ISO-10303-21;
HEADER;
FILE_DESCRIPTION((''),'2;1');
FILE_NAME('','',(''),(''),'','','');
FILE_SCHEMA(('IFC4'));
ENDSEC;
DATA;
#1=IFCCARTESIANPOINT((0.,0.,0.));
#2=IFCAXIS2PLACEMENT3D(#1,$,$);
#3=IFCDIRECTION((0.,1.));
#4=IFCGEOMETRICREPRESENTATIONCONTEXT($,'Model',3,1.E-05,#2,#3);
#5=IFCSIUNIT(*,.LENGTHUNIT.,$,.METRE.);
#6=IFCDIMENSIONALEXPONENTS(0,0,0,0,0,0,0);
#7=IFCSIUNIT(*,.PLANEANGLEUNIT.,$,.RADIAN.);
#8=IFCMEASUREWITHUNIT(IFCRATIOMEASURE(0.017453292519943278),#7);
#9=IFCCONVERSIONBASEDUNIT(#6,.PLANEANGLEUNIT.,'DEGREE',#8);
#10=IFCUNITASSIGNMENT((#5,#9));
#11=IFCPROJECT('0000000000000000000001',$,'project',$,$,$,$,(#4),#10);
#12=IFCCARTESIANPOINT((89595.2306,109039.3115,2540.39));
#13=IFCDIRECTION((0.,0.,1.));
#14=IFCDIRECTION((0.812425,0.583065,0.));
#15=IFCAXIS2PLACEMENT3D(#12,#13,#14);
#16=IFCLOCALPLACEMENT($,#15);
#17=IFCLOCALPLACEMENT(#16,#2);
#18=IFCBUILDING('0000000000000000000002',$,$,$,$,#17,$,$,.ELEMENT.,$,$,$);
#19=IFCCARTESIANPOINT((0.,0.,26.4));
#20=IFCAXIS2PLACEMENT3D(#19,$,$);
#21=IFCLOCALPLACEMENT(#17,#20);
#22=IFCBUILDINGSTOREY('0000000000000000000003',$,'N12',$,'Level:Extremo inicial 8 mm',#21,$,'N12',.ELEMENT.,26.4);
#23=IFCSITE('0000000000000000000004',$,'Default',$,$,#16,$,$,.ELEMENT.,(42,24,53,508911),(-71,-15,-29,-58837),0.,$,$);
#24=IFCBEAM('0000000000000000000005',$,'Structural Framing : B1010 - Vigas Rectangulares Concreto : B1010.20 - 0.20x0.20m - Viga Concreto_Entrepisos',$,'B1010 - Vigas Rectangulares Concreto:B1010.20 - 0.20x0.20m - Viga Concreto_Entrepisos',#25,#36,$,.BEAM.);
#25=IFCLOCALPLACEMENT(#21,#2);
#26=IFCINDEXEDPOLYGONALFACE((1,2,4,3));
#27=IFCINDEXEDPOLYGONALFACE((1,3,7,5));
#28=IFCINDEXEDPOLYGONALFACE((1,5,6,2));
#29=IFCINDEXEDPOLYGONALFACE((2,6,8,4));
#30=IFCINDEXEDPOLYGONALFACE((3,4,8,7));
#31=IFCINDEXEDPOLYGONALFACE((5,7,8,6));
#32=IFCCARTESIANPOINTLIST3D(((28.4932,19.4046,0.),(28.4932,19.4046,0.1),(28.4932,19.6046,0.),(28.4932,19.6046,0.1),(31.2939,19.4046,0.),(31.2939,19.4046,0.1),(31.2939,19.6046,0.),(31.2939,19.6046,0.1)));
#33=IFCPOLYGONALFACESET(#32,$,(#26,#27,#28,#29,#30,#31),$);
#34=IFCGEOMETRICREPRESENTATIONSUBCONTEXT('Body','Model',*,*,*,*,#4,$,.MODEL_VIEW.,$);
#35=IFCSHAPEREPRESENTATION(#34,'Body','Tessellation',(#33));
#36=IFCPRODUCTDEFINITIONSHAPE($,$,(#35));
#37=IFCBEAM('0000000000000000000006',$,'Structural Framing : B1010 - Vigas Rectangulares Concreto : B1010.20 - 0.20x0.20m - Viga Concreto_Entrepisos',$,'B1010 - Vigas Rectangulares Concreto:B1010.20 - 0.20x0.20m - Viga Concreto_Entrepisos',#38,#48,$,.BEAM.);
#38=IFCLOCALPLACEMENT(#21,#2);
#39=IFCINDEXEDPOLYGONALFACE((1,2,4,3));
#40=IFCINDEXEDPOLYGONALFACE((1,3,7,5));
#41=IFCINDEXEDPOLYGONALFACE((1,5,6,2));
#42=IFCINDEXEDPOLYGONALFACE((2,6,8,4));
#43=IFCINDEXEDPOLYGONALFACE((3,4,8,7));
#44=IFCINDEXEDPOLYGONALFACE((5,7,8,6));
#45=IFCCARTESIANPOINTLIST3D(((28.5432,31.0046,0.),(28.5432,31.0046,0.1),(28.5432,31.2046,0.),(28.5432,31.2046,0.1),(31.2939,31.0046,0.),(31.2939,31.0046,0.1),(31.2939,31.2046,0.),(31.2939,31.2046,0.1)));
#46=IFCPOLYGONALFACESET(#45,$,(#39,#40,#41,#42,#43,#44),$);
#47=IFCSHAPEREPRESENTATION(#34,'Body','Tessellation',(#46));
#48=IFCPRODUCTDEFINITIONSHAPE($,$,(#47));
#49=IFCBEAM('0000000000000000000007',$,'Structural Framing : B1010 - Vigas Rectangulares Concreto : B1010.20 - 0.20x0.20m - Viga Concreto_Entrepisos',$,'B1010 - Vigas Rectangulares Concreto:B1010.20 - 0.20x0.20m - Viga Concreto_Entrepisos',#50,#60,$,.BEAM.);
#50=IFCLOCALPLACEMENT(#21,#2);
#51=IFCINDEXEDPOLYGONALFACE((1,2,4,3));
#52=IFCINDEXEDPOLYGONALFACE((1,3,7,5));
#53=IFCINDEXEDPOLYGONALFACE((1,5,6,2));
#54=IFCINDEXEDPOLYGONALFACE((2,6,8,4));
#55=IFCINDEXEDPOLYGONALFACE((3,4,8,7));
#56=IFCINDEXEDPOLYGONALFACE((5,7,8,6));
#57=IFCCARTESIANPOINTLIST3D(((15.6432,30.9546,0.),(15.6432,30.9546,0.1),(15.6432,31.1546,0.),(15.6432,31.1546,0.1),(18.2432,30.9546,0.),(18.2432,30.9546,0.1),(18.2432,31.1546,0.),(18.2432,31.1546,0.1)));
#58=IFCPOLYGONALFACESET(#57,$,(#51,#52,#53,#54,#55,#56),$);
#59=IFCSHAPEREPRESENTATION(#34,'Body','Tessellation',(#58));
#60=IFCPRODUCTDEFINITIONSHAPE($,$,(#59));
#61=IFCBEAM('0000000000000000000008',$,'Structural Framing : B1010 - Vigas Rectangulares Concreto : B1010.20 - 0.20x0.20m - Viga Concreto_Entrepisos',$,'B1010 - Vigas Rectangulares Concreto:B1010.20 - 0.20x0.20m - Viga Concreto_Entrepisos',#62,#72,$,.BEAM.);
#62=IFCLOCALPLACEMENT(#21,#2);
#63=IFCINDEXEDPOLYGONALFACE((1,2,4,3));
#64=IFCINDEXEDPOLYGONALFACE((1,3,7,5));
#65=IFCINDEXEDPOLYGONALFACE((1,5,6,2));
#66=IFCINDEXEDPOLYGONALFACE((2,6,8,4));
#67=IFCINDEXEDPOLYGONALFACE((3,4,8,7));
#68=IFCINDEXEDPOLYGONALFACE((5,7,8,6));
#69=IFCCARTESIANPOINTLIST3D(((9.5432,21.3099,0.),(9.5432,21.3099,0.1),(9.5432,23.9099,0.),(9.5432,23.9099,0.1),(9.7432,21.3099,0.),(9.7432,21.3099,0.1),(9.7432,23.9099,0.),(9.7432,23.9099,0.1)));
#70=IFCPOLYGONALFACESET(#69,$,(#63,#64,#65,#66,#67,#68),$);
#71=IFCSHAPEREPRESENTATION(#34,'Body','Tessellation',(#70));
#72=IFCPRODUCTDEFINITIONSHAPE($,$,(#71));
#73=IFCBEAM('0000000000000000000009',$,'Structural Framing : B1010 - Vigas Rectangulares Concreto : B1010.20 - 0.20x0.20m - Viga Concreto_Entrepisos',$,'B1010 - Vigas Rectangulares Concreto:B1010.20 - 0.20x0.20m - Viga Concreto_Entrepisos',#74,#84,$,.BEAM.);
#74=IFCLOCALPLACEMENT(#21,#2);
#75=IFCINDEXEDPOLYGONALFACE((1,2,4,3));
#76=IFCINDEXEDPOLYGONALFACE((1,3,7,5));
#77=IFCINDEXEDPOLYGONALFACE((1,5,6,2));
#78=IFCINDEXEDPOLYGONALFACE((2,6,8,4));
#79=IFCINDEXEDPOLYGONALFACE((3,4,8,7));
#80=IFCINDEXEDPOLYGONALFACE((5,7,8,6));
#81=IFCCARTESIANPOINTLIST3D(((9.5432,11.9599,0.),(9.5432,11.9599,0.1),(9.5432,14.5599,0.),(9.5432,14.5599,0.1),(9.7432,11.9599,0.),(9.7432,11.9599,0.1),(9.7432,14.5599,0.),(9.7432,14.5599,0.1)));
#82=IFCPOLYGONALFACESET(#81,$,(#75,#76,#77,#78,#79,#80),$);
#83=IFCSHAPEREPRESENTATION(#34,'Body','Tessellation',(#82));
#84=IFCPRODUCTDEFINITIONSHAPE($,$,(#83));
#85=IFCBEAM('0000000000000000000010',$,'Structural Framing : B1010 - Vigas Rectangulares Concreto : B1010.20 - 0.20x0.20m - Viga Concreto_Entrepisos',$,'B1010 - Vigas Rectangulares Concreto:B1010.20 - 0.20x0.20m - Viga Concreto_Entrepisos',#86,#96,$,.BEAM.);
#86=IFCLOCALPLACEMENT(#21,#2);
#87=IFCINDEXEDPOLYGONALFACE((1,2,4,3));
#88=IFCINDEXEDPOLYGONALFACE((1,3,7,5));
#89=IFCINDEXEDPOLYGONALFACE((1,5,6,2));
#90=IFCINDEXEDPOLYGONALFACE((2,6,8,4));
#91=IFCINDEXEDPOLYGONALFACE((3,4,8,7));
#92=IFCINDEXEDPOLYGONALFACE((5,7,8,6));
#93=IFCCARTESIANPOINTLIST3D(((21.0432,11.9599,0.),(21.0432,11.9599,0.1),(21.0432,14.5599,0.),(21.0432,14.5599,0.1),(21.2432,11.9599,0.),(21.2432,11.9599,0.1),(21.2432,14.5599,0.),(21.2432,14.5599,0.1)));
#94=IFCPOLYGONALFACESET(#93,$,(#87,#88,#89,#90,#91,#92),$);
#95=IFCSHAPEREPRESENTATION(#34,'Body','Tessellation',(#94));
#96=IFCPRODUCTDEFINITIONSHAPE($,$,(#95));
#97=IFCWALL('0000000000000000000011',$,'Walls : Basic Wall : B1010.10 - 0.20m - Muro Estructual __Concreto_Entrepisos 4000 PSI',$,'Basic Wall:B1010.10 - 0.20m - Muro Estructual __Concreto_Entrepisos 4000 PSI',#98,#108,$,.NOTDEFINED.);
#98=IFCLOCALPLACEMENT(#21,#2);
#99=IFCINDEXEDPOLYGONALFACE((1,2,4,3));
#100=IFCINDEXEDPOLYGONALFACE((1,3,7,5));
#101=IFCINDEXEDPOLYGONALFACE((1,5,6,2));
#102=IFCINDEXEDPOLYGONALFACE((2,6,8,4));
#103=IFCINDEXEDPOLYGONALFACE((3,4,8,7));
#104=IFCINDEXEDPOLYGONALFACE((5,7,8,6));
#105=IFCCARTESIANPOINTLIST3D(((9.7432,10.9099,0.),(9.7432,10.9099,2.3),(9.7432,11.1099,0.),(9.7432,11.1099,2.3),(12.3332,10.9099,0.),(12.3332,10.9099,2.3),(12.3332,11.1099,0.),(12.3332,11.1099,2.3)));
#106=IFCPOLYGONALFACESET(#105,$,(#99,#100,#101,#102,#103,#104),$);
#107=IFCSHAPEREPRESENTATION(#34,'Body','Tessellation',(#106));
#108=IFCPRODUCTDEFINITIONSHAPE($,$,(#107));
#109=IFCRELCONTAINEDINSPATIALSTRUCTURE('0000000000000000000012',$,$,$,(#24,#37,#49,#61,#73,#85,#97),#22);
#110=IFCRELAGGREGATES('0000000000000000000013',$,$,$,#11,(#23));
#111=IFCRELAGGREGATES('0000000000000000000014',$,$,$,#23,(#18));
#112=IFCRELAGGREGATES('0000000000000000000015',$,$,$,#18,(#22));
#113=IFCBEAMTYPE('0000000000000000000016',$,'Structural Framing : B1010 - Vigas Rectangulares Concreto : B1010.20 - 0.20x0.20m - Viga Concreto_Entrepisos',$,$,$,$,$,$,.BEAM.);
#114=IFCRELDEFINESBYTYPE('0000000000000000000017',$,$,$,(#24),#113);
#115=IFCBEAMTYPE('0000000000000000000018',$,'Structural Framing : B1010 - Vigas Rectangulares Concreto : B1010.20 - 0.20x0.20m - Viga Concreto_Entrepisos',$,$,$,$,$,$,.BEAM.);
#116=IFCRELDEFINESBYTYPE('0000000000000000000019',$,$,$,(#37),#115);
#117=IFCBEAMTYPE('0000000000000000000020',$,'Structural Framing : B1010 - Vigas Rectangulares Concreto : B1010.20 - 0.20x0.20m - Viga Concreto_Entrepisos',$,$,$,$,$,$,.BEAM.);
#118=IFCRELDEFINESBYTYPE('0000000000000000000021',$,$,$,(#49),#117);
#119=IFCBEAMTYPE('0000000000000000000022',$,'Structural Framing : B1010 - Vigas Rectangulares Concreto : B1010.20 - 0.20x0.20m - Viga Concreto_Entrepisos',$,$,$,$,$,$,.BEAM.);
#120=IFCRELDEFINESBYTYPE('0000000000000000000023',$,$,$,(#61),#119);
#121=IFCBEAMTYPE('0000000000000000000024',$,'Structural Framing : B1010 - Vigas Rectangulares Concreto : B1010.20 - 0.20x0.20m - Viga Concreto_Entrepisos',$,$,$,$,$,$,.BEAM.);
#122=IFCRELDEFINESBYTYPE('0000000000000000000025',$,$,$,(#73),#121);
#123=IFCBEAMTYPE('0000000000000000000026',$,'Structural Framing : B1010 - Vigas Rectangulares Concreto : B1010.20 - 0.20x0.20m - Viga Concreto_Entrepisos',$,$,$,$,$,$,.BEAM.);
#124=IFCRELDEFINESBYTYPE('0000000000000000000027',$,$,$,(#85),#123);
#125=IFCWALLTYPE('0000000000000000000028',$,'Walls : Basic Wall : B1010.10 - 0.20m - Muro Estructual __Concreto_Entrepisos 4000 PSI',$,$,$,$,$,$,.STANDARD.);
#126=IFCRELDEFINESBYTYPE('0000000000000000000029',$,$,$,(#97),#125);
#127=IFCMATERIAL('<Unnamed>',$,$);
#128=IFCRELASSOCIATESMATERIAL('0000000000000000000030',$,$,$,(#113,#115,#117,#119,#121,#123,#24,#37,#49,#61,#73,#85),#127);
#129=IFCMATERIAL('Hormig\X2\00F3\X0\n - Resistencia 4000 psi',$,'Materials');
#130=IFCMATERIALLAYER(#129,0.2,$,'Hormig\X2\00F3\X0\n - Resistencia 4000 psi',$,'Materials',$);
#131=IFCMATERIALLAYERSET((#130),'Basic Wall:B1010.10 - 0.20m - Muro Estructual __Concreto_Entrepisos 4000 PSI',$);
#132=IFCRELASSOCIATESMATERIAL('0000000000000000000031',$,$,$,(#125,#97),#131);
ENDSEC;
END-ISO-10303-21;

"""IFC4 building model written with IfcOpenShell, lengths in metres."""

from ifc_helpers import new_model, entity, si_unit, converted_unit, direction, frame, frame_2d, origin, place, context, subcontext, project, spatial, polyline, segment, composite_curve, rectangle, outline, extrude, source, transform, mapped, material, layer, layer_set, layer_usage, material_profile, profile_set, profile_usage, type_object, type_shapes, element, save


model = new_model("IFC4")

# Units and contexts
model_context = context("Model", 3, precision=1e-05, world=origin(), true_north=direction((0.0, 1.0)))
body_context = subcontext(model_context, "Body", "Model", "MODEL_VIEW")
ifc_project = project(units=[si_unit("LENGTHUNIT", "METRE"), converted_unit("PLANEANGLEUNIT", "DEGREE", entity("IfcRatioMeasure", 0.017453292519943278), si_unit("PLANEANGLEUNIT", "RADIAN"), dimensions=[0, 0, 0, 0, 0, 0, 0])], contexts=[model_context])

# Site, building, storey
site_placement = place(None, frame((89595.2306, 109039.3115, 2540.39), z_axis=(0.0, 0.0, 1.0), x_axis=(0.812425, 0.583065, 0.0)))
site = spatial("IfcSite", under=ifc_project, at=site_placement, Name="Default", CompositionType="ELEMENT", RefLatitude=(42, 24, 53, 508911), RefLongitude=(-71, -15, -29, -58837), RefElevation=0.0)
building_placement = place(site_placement, origin())
building = spatial("IfcBuilding", under=site, at=building_placement, CompositionType="ELEMENT")
storey_placement = place(building_placement, frame((0.0, 0.0, 26.4)))
storey = spatial("IfcBuildingStorey", under=building, at=storey_placement, Name="N12", ObjectType="Level:Extremo inicial 8 mm", LongName="N12", CompositionType="ELEMENT", Elevation=26.4)

# Beams
ifc_material_1 = material(Name="<Unnamed>")
ifc_material_profile_1 = material_profile(ifc_material_1, outline(composite_curve([segment(polyline([(-0.1, 0.0, 0.0), (-0.1, 0.1, 0.0)]), True, "CONTINUOUS"), segment(polyline([(-0.1, 0.1, 0.0), (0.1, 0.1, 0.0)]), True, "CONTINUOUS"), segment(polyline([(0.1, 0.1, 0.0), (0.1, 0.0, 0.0)]), True, "CONTINUOUS"), segment(polyline([(0.1, 0.0, 0.0), (-0.1, 0.0, 0.0)]), True, "CONTINUOUS")], self_intersect=False), kind="CURVE"), Name="B1010.20 - 0.20x0.20m - Viga Concreto_Entrepisos")
ifc_material_profile_2 = material_profile(ifc_material_1, outline(composite_curve([segment(polyline([(-1.4004, -0.1, 0.1), (-1.4004, 0.1, 0.1)]), True, "CONTINUOUS"), segment(polyline([(-1.4004, 0.1, 0.1), (-1.4004, 0.1, -0.1)]), True, "CONTINUOUS"), segment(polyline([(-1.4004, 0.1, -0.1), (-1.4004, -0.1, -0.1)]), True, "CONTINUOUS"), segment(polyline([(-1.4004, -0.1, -0.1), (-1.4004, -0.1, 0.1)]), True, "CONTINUOUS")], self_intersect=False), kind="CURVE"), Name="B1010.20 - 0.20x0.20m - Viga Concreto_Entrepisos")
ifc_profile_set_1 = profile_set([ifc_material_profile_1, ifc_material_profile_2], Name="B1010.20 - 0.20x0.20m - Viga Concreto_Entrepisos")
ifc_profile_usage_1 = profile_usage(ifc_profile_set_1, cardinal=8)
beam_type_1 = type_object("IfcBeamType", Name="Structural Framing : B1010 - Vigas Rectangulares Concreto : B1010.20 - 0.20x0.20m - Viga Concreto_Entrepisos", PredefinedType="BEAM", material=ifc_profile_set_1)
shared_shape_1 = source(origin(), body_context, "Body", "SweptSolid", [
    extrude(rectangle(XDim=0.1, YDim=0.2, at=frame_2d((0.0, 0.0), x_axis=(1.0, 0.0))), frame((31.2939, 19.5046, 26.45), z_axis=(-1.0, 0.0, 0.0), x_axis=(0.0, 0.0, -1.0)), (0.0, 0.0, 1.0), 2.8007),
])
type_shapes(beam_type_1, [shared_shape_1])
beam_1_placement = place(storey_placement, frame((0.0, 0.0, -26.4)))
element("IfcBeam", 1, at=beam_1_placement, inside=storey, type_object=beam_type_1, material=ifc_profile_usage_1, Name="Structural Framing : B1010 - Vigas Rectangulares Concreto : B1010.20 - 0.20x0.20m - Viga Concreto_Entrepisos", ObjectType="B1010 - Vigas Rectangulares Concreto:B1010.20 - 0.20x0.20m - Viga Concreto_Entrepisos", PredefinedType="BEAM", context=body_context, shape_type="MappedRepresentation", body=[
    mapped(shared_shape_1, transform((0.0, 0.0, 0.0), scale=1.0)),
])
ifc_profile_usage_2 = profile_usage(ifc_profile_set_1, cardinal=8)
beam_type_2 = type_object("IfcBeamType", Name="Structural Framing : B1010 - Vigas Rectangulares Concreto : B1010.20 - 0.20x0.20m - Viga Concreto_Entrepisos", PredefinedType="BEAM", material=ifc_profile_set_1)
shared_shape_2 = source(origin(), body_context, "Body", "SweptSolid", [
    extrude(rectangle(XDim=0.1, YDim=0.2, at=frame_2d((0.0, 0.0), x_axis=(1.0, 0.0))), frame((31.2939, 31.1046, 26.45), z_axis=(-1.0, 0.0, 0.0), x_axis=(0.0, 0.0, -1.0)), (0.0, 0.0, 1.0), 2.7507),
])
type_shapes(beam_type_2, [shared_shape_2])
beam_2_placement = place(storey_placement, frame((0.0, 0.0, -26.4)))
element("IfcBeam", 2, at=beam_2_placement, inside=storey, type_object=beam_type_2, material=ifc_profile_usage_2, Name="Structural Framing : B1010 - Vigas Rectangulares Concreto : B1010.20 - 0.20x0.20m - Viga Concreto_Entrepisos", ObjectType="B1010 - Vigas Rectangulares Concreto:B1010.20 - 0.20x0.20m - Viga Concreto_Entrepisos", PredefinedType="BEAM", context=body_context, shape_type="MappedRepresentation", body=[
    mapped(shared_shape_2, transform((0.0, 0.0, 0.0), scale=1.0)),
])
ifc_profile_usage_3 = profile_usage(ifc_profile_set_1, cardinal=8)
beam_type_3 = type_object("IfcBeamType", Name="Structural Framing : B1010 - Vigas Rectangulares Concreto : B1010.20 - 0.20x0.20m - Viga Concreto_Entrepisos", PredefinedType="BEAM", material=ifc_profile_set_1)
shared_shape_3 = source(origin(), body_context, "Body", "SweptSolid", [
    extrude(rectangle(XDim=0.1, YDim=0.2, at=frame_2d((0.0, 0.0), x_axis=(1.0, 0.0))), frame((18.2432, 31.0546, 26.45), z_axis=(-1.0, 0.0, 0.0), x_axis=(0.0, 0.0, -1.0)), (0.0, 0.0, 1.0), 2.6),
])
type_shapes(beam_type_3, [shared_shape_3])
beam_3_placement = place(storey_placement, frame((0.0, 0.0, -26.4)))
element("IfcBeam", 3, at=beam_3_placement, inside=storey, type_object=beam_type_3, material=ifc_profile_usage_3, Name="Structural Framing : B1010 - Vigas Rectangulares Concreto : B1010.20 - 0.20x0.20m - Viga Concreto_Entrepisos", ObjectType="B1010 - Vigas Rectangulares Concreto:B1010.20 - 0.20x0.20m - Viga Concreto_Entrepisos", PredefinedType="BEAM", context=body_context, shape_type="MappedRepresentation", body=[
    mapped(shared_shape_3, transform((0.0, 0.0, 0.0), scale=1.0)),
])
ifc_profile_usage_4 = profile_usage(ifc_profile_set_1, cardinal=8)
beam_type_4 = type_object("IfcBeamType", Name="Structural Framing : B1010 - Vigas Rectangulares Concreto : B1010.20 - 0.20x0.20m - Viga Concreto_Entrepisos", PredefinedType="BEAM", material=ifc_profile_set_1)
shared_shape_4 = source(origin(), body_context, "Body", "SweptSolid", [
    extrude(rectangle(XDim=0.1, YDim=0.2, at=frame_2d((0.0, 0.0), x_axis=(0.0, 1.0))), frame((9.6432, 21.3099, 26.45), z_axis=(0.0, 1.0, 0.0), x_axis=(-1.0, 0.0, 0.0)), (0.0, 0.0, 1.0), 2.6),
])
type_shapes(beam_type_4, [shared_shape_4])
beam_4_placement = place(storey_placement, frame((0.0, 0.0, -26.4)))
element("IfcBeam", 4, at=beam_4_placement, inside=storey, type_object=beam_type_4, material=ifc_profile_usage_4, Name="Structural Framing : B1010 - Vigas Rectangulares Concreto : B1010.20 - 0.20x0.20m - Viga Concreto_Entrepisos", ObjectType="B1010 - Vigas Rectangulares Concreto:B1010.20 - 0.20x0.20m - Viga Concreto_Entrepisos", PredefinedType="BEAM", context=body_context, shape_type="MappedRepresentation", body=[
    mapped(shared_shape_4, transform((0.0, 0.0, 0.0), scale=1.0)),
])
ifc_profile_usage_5 = profile_usage(ifc_profile_set_1, cardinal=8)
beam_type_5 = type_object("IfcBeamType", Name="Structural Framing : B1010 - Vigas Rectangulares Concreto : B1010.20 - 0.20x0.20m - Viga Concreto_Entrepisos", PredefinedType="BEAM", material=ifc_profile_set_1)
shared_shape_5 = source(origin(), body_context, "Body", "SweptSolid", [
    extrude(rectangle(XDim=0.1, YDim=0.2, at=frame_2d((0.0, 0.0), x_axis=(0.0, 1.0))), frame((9.6432, 11.9599, 26.45), z_axis=(0.0, 1.0, 0.0), x_axis=(-1.0, 0.0, 0.0)), (0.0, 0.0, 1.0), 2.6),
])
type_shapes(beam_type_5, [shared_shape_5])
beam_5_placement = place(storey_placement, frame((0.0, 0.0, -26.4)))
element("IfcBeam", 5, at=beam_5_placement, inside=storey, type_object=beam_type_5, material=ifc_profile_usage_5, Name="Structural Framing : B1010 - Vigas Rectangulares Concreto : B1010.20 - 0.20x0.20m - Viga Concreto_Entrepisos", ObjectType="B1010 - Vigas Rectangulares Concreto:B1010.20 - 0.20x0.20m - Viga Concreto_Entrepisos", PredefinedType="BEAM", context=body_context, shape_type="MappedRepresentation", body=[
    mapped(shared_shape_5, transform((0.0, 0.0, 0.0), scale=1.0)),
])
ifc_profile_usage_6 = profile_usage(ifc_profile_set_1, cardinal=8)
beam_type_6 = type_object("IfcBeamType", Name="Structural Framing : B1010 - Vigas Rectangulares Concreto : B1010.20 - 0.20x0.20m - Viga Concreto_Entrepisos", PredefinedType="BEAM", material=ifc_profile_set_1)
shared_shape_6 = source(origin(), body_context, "Body", "SweptSolid", [
    extrude(rectangle(XDim=0.1, YDim=0.2, at=frame_2d((0.0, 0.0), x_axis=(0.0, 1.0))), frame((21.1432, 11.9599, 26.45), z_axis=(0.0, 1.0, 0.0), x_axis=(-1.0, 0.0, 0.0)), (0.0, 0.0, 1.0), 2.6),
])
type_shapes(beam_type_6, [shared_shape_6])
beam_6_placement = place(storey_placement, frame((0.0, 0.0, -26.4)))
element("IfcBeam", 6, at=beam_6_placement, inside=storey, type_object=beam_type_6, material=ifc_profile_usage_6, Name="Structural Framing : B1010 - Vigas Rectangulares Concreto : B1010.20 - 0.20x0.20m - Viga Concreto_Entrepisos", ObjectType="B1010 - Vigas Rectangulares Concreto:B1010.20 - 0.20x0.20m - Viga Concreto_Entrepisos", PredefinedType="BEAM", context=body_context, shape_type="MappedRepresentation", body=[
    mapped(shared_shape_6, transform((0.0, 0.0, 0.0), scale=1.0)),
])

# Wall
ifc_material_2 = material(Name="Hormigón - Resistencia 4000 psi", Category="Materials")
ifc_layer_1 = layer(ifc_material_2, 0.2, Name="Hormigón - Resistencia 4000 psi", Category="Materials")
ifc_layer_set_1 = layer_set([ifc_layer_1], Name="Basic Wall:B1010.10 - 0.20m - Muro Estructual __Concreto_Entrepisos 4000 PSI")
ifc_layer_usage_1 = layer_usage(ifc_layer_set_1, "AXIS2", "POSITIVE", -0.1)
wall_type = type_object("IfcWallType", Name="Walls : Basic Wall : B1010.10 - 0.20m - Muro Estructual __Concreto_Entrepisos 4000 PSI", PredefinedType="STANDARD", material=ifc_layer_set_1)
wall_placement = place(storey_placement, frame((9.7432, 11.0099, 0.0)))
element("IfcWall", 7, at=wall_placement, inside=storey, type_object=wall_type, material=ifc_layer_usage_1, Name="Walls : Basic Wall : B1010.10 - 0.20m - Muro Estructual __Concreto_Entrepisos 4000 PSI", ObjectType="Basic Wall:B1010.10 - 0.20m - Muro Estructual __Concreto_Entrepisos 4000 PSI", PredefinedType="NOTDEFINED", context=body_context, shape_type="SweptSolid", body=[
    extrude(rectangle(XDim=2.59, YDim=0.2, at=frame_2d((1.295, 0.0), x_axis=(-1.0, 0.0))), origin(), (0.0, 0.0, 1.0), 2.3),
])

save(model, "model.ifc")
